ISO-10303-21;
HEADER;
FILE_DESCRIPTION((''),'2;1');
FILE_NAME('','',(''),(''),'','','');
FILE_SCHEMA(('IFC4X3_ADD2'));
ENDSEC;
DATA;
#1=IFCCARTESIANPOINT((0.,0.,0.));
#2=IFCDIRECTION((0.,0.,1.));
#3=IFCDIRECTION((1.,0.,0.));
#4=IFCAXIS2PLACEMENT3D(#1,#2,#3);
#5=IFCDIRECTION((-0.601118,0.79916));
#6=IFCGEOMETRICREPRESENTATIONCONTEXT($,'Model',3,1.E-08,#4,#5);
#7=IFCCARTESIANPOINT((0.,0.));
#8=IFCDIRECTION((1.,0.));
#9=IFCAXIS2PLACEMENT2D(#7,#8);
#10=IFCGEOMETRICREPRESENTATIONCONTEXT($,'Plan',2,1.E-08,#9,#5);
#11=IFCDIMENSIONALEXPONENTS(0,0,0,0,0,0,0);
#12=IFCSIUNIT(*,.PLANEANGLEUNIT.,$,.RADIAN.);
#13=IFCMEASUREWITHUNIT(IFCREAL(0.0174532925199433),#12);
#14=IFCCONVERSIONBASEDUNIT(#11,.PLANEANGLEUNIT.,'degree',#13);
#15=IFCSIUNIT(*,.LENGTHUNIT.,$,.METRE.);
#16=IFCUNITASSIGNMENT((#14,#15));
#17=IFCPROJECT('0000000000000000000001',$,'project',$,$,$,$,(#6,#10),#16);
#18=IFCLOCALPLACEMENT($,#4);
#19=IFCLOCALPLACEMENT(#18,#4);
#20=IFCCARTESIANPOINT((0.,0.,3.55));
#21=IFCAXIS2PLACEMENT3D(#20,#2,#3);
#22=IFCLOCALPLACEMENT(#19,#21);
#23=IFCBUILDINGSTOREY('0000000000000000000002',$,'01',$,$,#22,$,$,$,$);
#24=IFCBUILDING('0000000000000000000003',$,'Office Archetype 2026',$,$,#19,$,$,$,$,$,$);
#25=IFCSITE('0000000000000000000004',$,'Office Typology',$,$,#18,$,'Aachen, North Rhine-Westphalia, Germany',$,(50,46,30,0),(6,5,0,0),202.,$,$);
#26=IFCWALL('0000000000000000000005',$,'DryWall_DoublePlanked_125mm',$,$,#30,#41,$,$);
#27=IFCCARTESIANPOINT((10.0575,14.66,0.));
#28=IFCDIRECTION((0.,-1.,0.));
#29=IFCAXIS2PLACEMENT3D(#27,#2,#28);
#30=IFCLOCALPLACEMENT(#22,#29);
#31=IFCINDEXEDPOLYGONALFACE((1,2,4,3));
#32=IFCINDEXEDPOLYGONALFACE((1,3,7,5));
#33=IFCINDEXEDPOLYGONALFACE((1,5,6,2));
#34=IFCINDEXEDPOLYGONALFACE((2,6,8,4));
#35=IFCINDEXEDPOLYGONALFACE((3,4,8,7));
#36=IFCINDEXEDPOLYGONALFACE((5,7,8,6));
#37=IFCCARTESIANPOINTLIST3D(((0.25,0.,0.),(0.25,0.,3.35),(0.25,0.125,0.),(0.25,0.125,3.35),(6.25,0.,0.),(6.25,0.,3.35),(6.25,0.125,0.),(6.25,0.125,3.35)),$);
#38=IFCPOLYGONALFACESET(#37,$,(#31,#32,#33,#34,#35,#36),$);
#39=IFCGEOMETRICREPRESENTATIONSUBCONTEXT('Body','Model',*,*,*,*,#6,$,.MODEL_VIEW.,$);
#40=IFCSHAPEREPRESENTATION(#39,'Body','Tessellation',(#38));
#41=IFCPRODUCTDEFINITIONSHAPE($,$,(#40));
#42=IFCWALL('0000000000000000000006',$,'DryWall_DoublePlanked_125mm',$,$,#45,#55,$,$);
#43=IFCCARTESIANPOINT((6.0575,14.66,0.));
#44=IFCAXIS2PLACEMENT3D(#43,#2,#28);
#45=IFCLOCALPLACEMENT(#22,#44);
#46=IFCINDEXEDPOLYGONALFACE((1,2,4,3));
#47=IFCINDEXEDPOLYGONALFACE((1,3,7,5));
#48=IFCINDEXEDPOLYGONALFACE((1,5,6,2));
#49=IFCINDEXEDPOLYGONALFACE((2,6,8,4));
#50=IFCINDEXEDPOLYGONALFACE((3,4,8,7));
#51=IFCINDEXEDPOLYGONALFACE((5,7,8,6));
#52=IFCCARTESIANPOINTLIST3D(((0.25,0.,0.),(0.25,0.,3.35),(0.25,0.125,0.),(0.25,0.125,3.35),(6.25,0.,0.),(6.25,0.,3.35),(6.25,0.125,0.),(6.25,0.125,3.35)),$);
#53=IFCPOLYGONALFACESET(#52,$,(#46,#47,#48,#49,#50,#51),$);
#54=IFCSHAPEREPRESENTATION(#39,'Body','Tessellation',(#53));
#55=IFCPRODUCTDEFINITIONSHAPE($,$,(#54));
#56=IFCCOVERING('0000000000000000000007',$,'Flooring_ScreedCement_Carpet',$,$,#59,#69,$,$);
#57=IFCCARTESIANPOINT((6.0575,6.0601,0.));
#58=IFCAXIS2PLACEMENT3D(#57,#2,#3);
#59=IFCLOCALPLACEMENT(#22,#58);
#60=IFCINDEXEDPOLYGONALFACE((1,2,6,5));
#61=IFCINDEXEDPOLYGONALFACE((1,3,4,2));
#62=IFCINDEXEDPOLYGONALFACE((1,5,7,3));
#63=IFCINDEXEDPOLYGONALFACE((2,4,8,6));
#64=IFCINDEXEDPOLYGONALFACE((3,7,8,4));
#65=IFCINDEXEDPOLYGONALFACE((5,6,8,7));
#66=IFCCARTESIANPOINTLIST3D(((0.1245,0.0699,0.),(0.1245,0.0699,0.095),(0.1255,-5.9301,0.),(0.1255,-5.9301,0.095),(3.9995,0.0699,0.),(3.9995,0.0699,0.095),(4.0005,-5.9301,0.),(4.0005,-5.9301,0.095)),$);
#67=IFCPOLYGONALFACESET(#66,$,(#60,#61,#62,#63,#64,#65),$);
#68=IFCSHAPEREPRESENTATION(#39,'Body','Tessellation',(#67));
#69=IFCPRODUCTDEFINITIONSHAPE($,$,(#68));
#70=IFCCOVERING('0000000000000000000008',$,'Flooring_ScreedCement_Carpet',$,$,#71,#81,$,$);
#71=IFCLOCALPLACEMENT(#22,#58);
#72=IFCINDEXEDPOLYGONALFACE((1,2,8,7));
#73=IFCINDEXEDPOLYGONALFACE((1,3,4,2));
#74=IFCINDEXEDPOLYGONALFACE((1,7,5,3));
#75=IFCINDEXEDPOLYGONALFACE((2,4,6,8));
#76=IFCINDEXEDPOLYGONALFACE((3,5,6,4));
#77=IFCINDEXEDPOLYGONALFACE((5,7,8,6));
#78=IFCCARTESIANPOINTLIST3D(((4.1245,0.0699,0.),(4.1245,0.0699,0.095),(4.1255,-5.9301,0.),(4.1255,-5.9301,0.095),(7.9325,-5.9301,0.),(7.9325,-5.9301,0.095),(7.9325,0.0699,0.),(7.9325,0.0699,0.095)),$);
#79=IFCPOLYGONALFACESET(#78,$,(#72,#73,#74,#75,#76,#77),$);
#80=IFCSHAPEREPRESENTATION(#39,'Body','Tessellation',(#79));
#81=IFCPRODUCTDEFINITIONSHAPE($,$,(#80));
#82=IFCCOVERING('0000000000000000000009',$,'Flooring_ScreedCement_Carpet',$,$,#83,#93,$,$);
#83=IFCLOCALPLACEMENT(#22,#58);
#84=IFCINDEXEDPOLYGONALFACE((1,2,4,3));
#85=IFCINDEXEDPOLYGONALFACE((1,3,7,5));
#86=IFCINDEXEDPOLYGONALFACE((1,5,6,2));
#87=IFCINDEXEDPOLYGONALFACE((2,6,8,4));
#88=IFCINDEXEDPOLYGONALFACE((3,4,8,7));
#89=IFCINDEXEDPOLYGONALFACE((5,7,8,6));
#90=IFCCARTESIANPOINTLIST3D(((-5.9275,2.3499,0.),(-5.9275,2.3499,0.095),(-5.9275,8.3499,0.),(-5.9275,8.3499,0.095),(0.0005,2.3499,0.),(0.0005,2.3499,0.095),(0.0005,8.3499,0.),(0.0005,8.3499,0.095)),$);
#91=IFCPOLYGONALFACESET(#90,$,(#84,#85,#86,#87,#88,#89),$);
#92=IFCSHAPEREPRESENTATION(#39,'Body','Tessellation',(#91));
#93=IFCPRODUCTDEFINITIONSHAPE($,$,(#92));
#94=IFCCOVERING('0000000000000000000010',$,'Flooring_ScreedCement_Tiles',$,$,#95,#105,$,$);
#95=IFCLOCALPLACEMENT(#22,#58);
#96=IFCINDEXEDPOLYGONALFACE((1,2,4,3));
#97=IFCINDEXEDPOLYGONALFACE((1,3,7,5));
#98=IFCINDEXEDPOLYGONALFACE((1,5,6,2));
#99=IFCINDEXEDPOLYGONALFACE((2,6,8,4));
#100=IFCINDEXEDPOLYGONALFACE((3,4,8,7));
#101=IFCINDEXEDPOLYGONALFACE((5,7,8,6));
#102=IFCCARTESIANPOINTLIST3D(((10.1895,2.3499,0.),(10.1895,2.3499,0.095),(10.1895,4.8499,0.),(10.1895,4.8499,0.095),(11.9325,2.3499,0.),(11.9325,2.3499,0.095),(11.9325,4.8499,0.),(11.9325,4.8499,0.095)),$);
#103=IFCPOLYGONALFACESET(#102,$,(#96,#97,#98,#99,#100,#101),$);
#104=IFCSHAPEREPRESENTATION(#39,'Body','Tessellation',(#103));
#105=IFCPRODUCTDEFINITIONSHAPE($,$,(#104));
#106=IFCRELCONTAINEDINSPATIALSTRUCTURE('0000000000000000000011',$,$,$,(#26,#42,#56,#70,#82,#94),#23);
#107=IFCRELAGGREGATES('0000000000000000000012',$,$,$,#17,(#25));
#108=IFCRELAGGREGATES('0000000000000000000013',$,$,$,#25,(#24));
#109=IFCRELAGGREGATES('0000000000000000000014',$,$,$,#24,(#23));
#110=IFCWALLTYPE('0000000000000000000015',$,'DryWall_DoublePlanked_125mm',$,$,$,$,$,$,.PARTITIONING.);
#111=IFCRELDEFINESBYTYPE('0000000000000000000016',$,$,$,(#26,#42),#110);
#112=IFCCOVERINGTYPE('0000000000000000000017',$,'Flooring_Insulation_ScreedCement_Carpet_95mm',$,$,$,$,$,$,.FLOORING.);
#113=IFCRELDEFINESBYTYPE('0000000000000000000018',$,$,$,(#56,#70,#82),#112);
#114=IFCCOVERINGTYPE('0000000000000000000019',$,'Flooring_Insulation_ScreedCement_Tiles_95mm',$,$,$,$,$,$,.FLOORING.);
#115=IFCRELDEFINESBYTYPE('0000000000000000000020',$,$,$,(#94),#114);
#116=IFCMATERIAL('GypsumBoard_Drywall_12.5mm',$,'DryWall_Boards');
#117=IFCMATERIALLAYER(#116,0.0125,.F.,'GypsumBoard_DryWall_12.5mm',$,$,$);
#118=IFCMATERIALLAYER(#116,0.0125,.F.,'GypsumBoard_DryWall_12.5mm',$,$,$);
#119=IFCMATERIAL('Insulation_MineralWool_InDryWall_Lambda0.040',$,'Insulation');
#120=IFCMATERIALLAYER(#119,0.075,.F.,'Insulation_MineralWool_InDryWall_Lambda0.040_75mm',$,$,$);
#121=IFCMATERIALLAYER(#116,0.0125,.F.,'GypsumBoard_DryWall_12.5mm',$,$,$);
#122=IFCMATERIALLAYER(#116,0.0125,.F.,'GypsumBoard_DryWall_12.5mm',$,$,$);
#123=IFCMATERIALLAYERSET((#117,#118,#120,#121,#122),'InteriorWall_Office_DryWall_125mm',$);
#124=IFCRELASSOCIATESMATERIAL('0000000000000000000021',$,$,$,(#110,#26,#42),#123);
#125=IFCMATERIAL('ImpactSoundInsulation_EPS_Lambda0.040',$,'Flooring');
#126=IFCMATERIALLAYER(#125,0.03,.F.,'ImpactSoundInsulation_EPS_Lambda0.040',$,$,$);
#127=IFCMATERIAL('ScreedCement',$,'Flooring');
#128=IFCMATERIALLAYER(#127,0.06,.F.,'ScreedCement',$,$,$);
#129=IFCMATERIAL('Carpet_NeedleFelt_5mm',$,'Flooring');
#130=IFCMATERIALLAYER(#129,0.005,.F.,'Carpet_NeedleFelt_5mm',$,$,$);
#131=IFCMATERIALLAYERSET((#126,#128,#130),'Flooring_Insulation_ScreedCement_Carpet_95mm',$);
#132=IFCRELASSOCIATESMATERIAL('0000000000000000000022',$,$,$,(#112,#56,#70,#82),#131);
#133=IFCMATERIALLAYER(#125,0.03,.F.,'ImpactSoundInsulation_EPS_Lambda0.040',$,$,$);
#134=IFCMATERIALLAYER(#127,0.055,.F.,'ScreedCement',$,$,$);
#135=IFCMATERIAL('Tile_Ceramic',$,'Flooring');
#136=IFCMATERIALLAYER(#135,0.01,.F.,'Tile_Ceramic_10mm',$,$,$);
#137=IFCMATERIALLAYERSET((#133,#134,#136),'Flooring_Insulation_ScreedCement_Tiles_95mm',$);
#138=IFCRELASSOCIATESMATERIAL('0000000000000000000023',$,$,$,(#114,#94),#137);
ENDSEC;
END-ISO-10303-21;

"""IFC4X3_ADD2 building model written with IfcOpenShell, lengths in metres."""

from ifc_helpers import new_model, entity, si_unit, converted_unit, direction, frame, origin_with_axes, origin_2d_with_axis, place, context, subcontext, project, spatial, line, indexed_curve, outline, extrude, material, layer, layer_set, layer_usage, type_object, element, save


model = new_model("IFC4X3_ADD2")

# Units and contexts
model_context = context("Model", 3, precision=1e-08, world=origin_with_axes(), true_north=direction((-0.601118, 0.79916)))
plan_context = context("Plan", 2, precision=1e-08, world=origin_2d_with_axis(), true_north=direction((-0.601118, 0.79916)))
body_context = subcontext(model_context, "Body", "Model", "MODEL_VIEW")
ifc_project = project(units=[converted_unit("PLANEANGLEUNIT", "degree", entity("IfcReal", 0.0174532925199433), si_unit("PLANEANGLEUNIT", "RADIAN"), dimensions=[0, 0, 0, 0, 0, 0, 0]), si_unit("LENGTHUNIT", "METRE")], contexts=[model_context, plan_context])

# Site, building, storey
site_placement = place(None, origin_with_axes())
site = spatial("IfcSite", under=ifc_project, at=site_placement, Name="Office Typology", LongName="Aachen, North Rhine-Westphalia, Germany", RefLatitude=(50, 46, 30, 0), RefLongitude=(6, 5, 0, 0), RefElevation=202.0)
building_placement = place(site_placement, origin_with_axes())
building = spatial("IfcBuilding", under=site, at=building_placement, Name="Office Archetype 2026")
storey_placement = place(building_placement, frame((0.0, 0.0, 3.55), z_axis=(0.0, 0.0, 1.0), x_axis=(1.0, 0.0, 0.0)))
storey = spatial("IfcBuildingStorey", under=building, at=storey_placement, Name="01")

# Walls
ifc_material_1 = material(Name="GypsumBoard_Drywall_12.5mm", Category="DryWall_Boards")
ifc_layer_1 = layer(ifc_material_1, 0.0125, ventilated=False, Name="GypsumBoard_DryWall_12.5mm")
ifc_layer_2 = layer(ifc_material_1, 0.0125, ventilated=False, Name="GypsumBoard_DryWall_12.5mm")
ifc_material_2 = material(Name="Insulation_MineralWool_InDryWall_Lambda0.040", Category="Insulation")
ifc_layer_3 = layer(ifc_material_2, 0.075, ventilated=False, Name="Insulation_MineralWool_InDryWall_Lambda0.040_75mm")
ifc_layer_4 = layer(ifc_material_1, 0.0125, ventilated=False, Name="GypsumBoard_DryWall_12.5mm")
ifc_layer_5 = layer(ifc_material_1, 0.0125, ventilated=False, Name="GypsumBoard_DryWall_12.5mm")
ifc_layer_set_1 = layer_set([ifc_layer_1, ifc_layer_2, ifc_layer_3, ifc_layer_4, ifc_layer_5], Name="InteriorWall_Office_DryWall_125mm")
ifc_layer_usage_1 = layer_usage(ifc_layer_set_1, "AXIS2", "POSITIVE", 0.0)
wall_type_1 = type_object("IfcWallType", Name="DryWall_DoublePlanked_125mm", PredefinedType="PARTITIONING", material=ifc_layer_set_1)
wall_1_placement = place(storey_placement, frame((10.0575, 14.66, 0.0), z_axis=(0.0, 0.0, 1.0), x_axis=(0.0, -1.0, 0.0)))
element("IfcWall", 1, at=wall_1_placement, inside=storey, type_object=wall_type_1, material=ifc_layer_usage_1, Name="DryWall_DoublePlanked_125mm", context=body_context, shape_type="SweptSolid", body=[
    extrude(outline(indexed_curve([(0.25, 0.0), (0.25, 0.125), (6.25, 0.125), (6.25, 0.0)], segments=[line(1, 2, 3, 4, 1)])), origin_with_axes(), (0.0, 0.0, 1.0), 3.35),
])
ifc_layer_usage_2 = layer_usage(ifc_layer_set_1, "AXIS2", "POSITIVE", 0.0)
wall_2_placement = place(storey_placement, frame((6.0575, 14.66, 0.0), z_axis=(0.0, 0.0, 1.0), x_axis=(0.0, -1.0, 0.0)))
element("IfcWall", 2, at=wall_2_placement, inside=storey, type_object=wall_type_1, material=ifc_layer_usage_2, Name="DryWall_DoublePlanked_125mm", context=body_context, shape_type="SweptSolid", body=[
    extrude(outline(indexed_curve([(0.25, 0.0), (0.25, 0.125), (6.25, 0.125), (6.25, 0.0)], segments=[line(1, 2, 3, 4, 1)])), origin_with_axes(), (0.0, 0.0, 1.0), 3.35),
])

# Coverings
ifc_material_3 = material(Name="ImpactSoundInsulation_EPS_Lambda0.040", Category="Flooring")
ifc_layer_6 = layer(ifc_material_3, 0.03, ventilated=False, Name="ImpactSoundInsulation_EPS_Lambda0.040")
ifc_material_4 = material(Name="ScreedCement", Category="Flooring")
ifc_layer_7 = layer(ifc_material_4, 0.06, ventilated=False, Name="ScreedCement")
ifc_material_5 = material(Name="Carpet_NeedleFelt_5mm", Category="Flooring")
ifc_layer_8 = layer(ifc_material_5, 0.005, ventilated=False, Name="Carpet_NeedleFelt_5mm")
ifc_layer_set_2 = layer_set([ifc_layer_6, ifc_layer_7, ifc_layer_8], Name="Flooring_Insulation_ScreedCement_Carpet_95mm")
ifc_layer_usage_3 = layer_usage(ifc_layer_set_2, "AXIS3", "POSITIVE", 0.0)
covering_type_1 = type_object("IfcCoveringType", Name="Flooring_Insulation_ScreedCement_Carpet_95mm", PredefinedType="FLOORING", material=ifc_layer_set_2)
covering_1_placement = place(storey_placement, frame((6.0575, 6.0601, 0.0), z_axis=(0.0, 0.0, 1.0), x_axis=(1.0, 0.0, 0.0)))
element("IfcCovering", 3, at=covering_1_placement, inside=storey, type_object=covering_type_1, material=ifc_layer_usage_3, Name="Flooring_ScreedCement_Carpet", context=body_context, shape_type="SweptSolid", body=[
    extrude(outline(indexed_curve([(0.1255, -5.9301), (0.1245, 0.0699), (3.9995, 0.0699), (4.0005, -5.9301)], segments=[line(1, 2, 3, 4, 1)])), origin_with_axes(), (0.0, 0.0, 1.0), 0.095),
])
ifc_layer_usage_4 = layer_usage(ifc_layer_set_2, "AXIS3", "POSITIVE", 0.0)
covering_2_placement = place(storey_placement, frame((6.0575, 6.0601, 0.0), z_axis=(0.0, 0.0, 1.0), x_axis=(1.0, 0.0, 0.0)))
element("IfcCovering", 4, at=covering_2_placement, inside=storey, type_object=covering_type_1, material=ifc_layer_usage_4, Name="Flooring_ScreedCement_Carpet", context=body_context, shape_type="SweptSolid", body=[
    extrude(outline(indexed_curve([(4.1245, 0.0699), (7.9325, 0.0699), (7.9325, -5.9301), (4.1255, -5.9301)], segments=[line(1, 2, 3, 4, 1)])), origin_with_axes(), (0.0, 0.0, 1.0), 0.095),
])
ifc_layer_usage_5 = layer_usage(ifc_layer_set_2, "AXIS3", "POSITIVE", 0.0)
covering_3_placement = place(storey_placement, frame((6.0575, 6.0601, 0.0), z_axis=(0.0, 0.0, 1.0), x_axis=(1.0, 0.0, 0.0)))
element("IfcCovering", 5, at=covering_3_placement, inside=storey, type_object=covering_type_1, material=ifc_layer_usage_5, Name="Flooring_ScreedCement_Carpet", context=body_context, shape_type="SweptSolid", body=[
    extrude(outline(indexed_curve([(-5.9275, 2.3499), (-5.9275, 8.3499), (0.0005, 8.3499), (0.0005, 2.3499)], segments=[line(1, 2, 3, 4, 1)])), origin_with_axes(), (0.0, 0.0, 1.0), 0.095),
])
ifc_layer_9 = layer(ifc_material_3, 0.03, ventilated=False, Name="ImpactSoundInsulation_EPS_Lambda0.040")
ifc_layer_10 = layer(ifc_material_4, 0.055, ventilated=False, Name="ScreedCement")
ifc_material_6 = material(Name="Tile_Ceramic", Category="Flooring")
ifc_layer_11 = layer(ifc_material_6, 0.01, ventilated=False, Name="Tile_Ceramic_10mm")
ifc_layer_set_3 = layer_set([ifc_layer_9, ifc_layer_10, ifc_layer_11], Name="Flooring_Insulation_ScreedCement_Tiles_95mm")
ifc_layer_usage_6 = layer_usage(ifc_layer_set_3, "AXIS3", "POSITIVE", 0.0)
covering_type_2 = type_object("IfcCoveringType", Name="Flooring_Insulation_ScreedCement_Tiles_95mm", PredefinedType="FLOORING", material=ifc_layer_set_3)
covering_4_placement = place(storey_placement, frame((6.0575, 6.0601, 0.0), z_axis=(0.0, 0.0, 1.0), x_axis=(1.0, 0.0, 0.0)))
element("IfcCovering", 6, at=covering_4_placement, inside=storey, type_object=covering_type_2, material=ifc_layer_usage_6, Name="Flooring_ScreedCement_Tiles", context=body_context, shape_type="SweptSolid", body=[
    extrude(outline(indexed_curve([(11.9325, 4.8499), (11.9325, 2.3499), (10.1895, 2.3499), (10.1895, 4.8499)], segments=[line(1, 2, 3, 4, 1)])), None, (0.0, 0.0, 1.0), 0.095),
])

save(model, "model.ifc")
